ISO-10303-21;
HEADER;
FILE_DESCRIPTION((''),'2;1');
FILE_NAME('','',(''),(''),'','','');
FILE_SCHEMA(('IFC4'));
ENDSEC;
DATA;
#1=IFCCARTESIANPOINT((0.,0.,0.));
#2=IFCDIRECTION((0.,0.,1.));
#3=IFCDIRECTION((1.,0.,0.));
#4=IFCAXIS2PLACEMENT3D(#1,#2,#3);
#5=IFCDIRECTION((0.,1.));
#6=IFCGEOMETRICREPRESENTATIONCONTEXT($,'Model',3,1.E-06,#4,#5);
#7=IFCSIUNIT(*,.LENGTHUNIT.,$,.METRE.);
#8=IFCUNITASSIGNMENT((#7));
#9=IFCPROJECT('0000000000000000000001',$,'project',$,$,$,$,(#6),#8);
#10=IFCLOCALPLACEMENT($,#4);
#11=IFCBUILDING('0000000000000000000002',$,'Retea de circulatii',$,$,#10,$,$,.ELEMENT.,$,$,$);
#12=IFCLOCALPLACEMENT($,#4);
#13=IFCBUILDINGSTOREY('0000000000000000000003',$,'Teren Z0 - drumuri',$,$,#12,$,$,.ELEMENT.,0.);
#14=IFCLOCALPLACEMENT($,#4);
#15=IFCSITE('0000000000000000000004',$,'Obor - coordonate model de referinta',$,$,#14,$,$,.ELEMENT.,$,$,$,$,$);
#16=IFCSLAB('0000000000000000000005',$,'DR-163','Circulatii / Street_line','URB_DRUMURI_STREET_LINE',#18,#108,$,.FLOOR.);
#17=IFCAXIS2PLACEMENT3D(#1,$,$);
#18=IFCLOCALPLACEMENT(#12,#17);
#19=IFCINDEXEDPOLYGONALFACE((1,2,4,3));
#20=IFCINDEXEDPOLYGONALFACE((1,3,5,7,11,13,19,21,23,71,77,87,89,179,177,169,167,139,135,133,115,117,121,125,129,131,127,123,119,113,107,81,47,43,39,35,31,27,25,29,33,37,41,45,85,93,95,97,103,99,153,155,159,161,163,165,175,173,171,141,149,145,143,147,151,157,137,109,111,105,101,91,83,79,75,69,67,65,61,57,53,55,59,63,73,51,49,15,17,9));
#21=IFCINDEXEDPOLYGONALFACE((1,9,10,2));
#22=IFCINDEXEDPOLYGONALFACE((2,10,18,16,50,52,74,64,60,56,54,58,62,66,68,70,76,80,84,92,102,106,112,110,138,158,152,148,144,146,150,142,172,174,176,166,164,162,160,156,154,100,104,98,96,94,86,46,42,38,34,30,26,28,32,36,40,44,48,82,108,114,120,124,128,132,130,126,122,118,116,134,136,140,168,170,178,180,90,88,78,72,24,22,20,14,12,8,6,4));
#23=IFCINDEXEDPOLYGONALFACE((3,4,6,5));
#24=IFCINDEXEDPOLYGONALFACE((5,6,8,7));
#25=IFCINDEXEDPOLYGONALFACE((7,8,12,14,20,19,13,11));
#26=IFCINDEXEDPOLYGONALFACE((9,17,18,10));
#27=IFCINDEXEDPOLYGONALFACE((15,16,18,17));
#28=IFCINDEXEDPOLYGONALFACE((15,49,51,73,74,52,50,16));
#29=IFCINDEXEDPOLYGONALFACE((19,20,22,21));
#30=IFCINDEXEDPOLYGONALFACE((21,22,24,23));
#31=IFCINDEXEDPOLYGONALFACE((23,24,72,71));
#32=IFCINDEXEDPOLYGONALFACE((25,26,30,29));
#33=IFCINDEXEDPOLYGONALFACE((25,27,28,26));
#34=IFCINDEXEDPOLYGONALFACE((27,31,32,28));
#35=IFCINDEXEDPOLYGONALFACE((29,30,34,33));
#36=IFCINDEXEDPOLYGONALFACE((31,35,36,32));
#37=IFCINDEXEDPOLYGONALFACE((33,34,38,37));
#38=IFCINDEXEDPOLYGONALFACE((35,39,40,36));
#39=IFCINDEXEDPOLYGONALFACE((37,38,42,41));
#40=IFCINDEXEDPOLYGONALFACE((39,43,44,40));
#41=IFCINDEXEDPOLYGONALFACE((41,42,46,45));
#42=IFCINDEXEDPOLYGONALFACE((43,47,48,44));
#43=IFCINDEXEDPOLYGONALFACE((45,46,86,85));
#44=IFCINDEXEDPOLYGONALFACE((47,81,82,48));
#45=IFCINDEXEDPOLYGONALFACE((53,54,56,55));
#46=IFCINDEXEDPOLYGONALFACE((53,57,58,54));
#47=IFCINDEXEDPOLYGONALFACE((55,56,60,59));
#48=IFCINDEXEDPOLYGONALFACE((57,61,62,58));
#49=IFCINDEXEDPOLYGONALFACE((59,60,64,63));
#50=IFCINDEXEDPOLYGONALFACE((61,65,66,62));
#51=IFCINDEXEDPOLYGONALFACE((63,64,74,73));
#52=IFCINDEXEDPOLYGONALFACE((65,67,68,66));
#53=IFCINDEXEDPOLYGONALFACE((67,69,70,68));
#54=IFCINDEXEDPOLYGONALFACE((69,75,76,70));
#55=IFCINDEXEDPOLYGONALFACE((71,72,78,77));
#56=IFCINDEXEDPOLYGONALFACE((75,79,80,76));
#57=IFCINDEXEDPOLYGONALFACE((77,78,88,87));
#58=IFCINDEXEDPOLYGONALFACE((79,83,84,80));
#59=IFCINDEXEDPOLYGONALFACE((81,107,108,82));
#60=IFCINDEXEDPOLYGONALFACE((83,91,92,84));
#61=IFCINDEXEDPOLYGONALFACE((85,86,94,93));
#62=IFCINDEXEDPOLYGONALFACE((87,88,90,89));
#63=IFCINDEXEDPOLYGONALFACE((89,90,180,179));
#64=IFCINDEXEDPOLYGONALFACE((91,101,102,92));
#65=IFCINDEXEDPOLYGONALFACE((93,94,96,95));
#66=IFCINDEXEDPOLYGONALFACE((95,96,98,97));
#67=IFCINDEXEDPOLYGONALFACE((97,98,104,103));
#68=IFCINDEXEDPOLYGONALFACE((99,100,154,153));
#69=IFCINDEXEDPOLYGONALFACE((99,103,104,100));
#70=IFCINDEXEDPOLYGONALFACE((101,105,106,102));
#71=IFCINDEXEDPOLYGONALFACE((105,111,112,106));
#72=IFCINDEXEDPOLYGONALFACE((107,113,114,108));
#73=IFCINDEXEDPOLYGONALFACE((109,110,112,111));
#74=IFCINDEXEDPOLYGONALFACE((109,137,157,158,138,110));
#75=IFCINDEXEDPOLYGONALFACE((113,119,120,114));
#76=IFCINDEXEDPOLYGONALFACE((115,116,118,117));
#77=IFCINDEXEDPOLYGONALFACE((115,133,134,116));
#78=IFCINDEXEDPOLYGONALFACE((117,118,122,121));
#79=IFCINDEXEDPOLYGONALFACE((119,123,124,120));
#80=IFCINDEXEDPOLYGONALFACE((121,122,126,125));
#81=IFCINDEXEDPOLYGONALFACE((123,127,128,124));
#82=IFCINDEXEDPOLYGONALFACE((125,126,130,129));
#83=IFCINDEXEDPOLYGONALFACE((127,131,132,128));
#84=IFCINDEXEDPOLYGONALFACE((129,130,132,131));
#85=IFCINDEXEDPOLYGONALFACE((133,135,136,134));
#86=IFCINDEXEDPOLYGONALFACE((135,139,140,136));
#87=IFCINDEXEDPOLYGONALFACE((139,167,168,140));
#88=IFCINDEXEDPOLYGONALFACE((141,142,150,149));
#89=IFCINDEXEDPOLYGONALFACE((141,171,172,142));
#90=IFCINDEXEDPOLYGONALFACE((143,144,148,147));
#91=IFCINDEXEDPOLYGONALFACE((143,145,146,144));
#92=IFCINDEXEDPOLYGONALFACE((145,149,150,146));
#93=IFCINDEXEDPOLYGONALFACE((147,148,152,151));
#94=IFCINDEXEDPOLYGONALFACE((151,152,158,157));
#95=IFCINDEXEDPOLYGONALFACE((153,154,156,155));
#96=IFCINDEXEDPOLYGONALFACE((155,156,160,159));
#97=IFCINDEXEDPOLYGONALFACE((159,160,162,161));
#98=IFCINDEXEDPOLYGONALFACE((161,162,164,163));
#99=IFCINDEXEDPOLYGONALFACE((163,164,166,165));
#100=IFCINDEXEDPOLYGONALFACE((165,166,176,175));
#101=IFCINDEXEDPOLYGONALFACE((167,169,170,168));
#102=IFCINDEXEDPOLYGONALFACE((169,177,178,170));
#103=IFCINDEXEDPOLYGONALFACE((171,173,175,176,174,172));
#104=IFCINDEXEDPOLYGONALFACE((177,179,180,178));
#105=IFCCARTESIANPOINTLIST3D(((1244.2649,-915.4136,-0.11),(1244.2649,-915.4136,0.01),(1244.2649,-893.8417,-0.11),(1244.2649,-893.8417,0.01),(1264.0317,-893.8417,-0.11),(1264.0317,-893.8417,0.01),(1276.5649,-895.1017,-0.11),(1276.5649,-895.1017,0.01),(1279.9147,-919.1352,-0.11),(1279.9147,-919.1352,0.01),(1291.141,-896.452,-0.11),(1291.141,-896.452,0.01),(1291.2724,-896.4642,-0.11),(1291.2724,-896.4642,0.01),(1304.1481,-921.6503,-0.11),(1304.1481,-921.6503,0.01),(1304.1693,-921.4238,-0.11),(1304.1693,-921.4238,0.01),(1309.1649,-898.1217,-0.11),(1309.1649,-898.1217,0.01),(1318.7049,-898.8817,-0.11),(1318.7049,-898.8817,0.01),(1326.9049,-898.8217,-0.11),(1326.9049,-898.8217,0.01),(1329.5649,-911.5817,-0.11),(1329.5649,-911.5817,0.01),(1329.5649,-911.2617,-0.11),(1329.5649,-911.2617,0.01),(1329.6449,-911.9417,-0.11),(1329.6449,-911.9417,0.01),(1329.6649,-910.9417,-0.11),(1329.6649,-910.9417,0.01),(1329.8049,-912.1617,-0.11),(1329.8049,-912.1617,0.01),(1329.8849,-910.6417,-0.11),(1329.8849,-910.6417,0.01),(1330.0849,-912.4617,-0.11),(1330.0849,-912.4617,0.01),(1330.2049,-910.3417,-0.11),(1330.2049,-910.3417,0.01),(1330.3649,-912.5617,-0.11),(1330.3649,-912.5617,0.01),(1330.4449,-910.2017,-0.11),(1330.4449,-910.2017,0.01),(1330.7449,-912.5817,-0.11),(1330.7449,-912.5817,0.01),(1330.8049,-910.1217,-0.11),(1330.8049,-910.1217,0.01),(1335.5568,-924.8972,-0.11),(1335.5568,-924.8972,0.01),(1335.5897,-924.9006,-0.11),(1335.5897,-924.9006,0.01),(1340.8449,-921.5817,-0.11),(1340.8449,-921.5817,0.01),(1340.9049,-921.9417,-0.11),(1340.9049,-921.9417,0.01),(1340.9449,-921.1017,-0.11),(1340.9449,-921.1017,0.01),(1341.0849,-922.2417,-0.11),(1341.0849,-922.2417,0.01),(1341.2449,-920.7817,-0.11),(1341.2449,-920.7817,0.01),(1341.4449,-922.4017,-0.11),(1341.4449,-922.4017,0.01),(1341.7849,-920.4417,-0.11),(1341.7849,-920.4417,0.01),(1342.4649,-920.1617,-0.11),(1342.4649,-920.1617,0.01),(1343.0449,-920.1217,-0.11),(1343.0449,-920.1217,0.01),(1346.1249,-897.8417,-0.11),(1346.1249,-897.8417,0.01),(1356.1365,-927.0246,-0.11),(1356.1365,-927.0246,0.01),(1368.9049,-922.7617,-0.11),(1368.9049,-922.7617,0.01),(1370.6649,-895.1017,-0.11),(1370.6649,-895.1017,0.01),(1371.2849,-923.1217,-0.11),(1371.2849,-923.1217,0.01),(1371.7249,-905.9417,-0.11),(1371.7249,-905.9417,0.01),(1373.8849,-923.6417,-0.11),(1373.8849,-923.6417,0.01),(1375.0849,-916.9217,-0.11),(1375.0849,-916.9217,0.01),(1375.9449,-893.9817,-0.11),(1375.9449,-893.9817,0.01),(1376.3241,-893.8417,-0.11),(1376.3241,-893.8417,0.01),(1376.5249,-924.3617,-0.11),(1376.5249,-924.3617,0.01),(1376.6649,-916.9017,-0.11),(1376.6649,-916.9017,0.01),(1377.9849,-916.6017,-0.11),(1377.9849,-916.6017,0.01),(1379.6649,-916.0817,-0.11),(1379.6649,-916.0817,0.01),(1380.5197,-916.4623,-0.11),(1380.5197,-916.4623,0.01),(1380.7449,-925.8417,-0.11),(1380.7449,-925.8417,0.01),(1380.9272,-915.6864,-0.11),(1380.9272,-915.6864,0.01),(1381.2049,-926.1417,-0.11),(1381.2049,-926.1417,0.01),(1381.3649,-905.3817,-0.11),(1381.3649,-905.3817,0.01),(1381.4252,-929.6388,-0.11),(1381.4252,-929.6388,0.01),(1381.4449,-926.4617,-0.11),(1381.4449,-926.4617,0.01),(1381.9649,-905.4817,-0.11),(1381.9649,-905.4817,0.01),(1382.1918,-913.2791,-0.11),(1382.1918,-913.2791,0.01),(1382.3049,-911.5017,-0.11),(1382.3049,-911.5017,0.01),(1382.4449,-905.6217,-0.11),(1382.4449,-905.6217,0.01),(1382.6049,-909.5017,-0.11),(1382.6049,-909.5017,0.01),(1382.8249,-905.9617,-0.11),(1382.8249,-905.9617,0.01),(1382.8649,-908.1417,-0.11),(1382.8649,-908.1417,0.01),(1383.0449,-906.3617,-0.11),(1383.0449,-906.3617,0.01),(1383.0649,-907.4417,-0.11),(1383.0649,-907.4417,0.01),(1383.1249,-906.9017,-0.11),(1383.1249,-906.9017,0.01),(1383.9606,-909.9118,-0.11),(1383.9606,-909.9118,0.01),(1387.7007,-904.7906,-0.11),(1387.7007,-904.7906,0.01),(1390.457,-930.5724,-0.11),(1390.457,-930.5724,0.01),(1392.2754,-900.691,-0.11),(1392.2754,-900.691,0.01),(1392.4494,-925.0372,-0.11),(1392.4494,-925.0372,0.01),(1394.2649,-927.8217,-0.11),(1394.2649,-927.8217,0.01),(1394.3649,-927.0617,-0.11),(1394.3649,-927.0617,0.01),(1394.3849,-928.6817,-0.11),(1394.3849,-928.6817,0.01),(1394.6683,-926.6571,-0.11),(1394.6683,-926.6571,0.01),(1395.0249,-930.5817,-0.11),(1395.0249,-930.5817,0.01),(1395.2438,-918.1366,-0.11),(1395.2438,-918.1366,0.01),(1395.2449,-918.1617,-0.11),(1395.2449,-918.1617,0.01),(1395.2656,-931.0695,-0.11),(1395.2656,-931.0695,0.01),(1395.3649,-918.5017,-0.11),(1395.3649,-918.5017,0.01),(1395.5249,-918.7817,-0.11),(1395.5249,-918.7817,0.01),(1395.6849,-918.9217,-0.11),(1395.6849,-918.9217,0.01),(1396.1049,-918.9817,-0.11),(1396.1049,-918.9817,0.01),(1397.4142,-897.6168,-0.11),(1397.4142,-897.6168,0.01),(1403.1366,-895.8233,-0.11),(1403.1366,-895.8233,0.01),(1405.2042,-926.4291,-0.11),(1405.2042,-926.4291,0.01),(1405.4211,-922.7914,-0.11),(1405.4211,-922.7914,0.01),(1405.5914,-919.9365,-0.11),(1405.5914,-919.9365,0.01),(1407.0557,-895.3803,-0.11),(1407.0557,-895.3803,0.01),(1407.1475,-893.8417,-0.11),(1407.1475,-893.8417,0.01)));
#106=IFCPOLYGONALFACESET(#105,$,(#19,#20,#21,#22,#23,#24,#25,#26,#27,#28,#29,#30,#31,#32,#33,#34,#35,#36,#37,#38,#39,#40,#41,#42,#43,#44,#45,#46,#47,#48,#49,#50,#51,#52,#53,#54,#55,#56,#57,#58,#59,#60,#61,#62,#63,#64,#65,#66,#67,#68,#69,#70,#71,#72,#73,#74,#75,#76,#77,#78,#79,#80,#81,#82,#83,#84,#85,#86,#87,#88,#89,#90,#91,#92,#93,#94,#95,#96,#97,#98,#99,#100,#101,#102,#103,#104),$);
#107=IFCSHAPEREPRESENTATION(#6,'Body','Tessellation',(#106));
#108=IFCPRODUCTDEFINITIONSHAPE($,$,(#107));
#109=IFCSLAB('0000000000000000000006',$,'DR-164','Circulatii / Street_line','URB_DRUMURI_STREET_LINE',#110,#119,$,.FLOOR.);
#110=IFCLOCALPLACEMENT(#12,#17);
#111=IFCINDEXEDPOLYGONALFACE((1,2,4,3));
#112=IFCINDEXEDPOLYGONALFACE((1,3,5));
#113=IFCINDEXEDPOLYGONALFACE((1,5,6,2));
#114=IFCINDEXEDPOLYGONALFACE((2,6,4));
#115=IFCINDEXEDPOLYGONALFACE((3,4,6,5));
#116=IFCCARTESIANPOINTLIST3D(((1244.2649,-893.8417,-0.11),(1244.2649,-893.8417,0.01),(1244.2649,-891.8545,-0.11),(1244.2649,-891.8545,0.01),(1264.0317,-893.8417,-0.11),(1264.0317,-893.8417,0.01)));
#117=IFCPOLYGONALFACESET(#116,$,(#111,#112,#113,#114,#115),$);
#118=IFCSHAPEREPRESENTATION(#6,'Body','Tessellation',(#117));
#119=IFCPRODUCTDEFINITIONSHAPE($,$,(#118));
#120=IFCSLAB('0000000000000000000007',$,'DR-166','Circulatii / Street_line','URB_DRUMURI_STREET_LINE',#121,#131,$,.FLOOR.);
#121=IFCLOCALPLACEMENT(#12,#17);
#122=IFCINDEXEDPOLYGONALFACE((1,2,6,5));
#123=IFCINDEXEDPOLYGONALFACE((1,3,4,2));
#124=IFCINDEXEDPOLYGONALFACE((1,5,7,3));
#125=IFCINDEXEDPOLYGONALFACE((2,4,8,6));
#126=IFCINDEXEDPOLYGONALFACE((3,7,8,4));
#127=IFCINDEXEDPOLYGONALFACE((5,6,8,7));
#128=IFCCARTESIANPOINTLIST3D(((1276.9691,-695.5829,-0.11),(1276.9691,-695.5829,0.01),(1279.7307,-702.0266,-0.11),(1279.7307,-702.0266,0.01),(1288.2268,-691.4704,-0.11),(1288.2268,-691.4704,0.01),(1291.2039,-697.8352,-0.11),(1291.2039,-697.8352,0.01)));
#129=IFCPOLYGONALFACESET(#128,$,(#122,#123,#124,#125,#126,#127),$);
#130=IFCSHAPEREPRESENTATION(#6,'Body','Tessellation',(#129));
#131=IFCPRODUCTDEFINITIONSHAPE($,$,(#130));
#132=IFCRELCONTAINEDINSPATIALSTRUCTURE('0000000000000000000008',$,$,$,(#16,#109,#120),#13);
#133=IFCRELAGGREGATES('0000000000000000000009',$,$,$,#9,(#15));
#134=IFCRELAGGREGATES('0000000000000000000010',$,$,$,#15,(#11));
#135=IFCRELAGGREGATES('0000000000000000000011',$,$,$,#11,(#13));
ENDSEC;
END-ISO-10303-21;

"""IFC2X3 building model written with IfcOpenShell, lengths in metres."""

from ifc_helpers import new_model, si_unit, direction, frame, origin_with_axes, place, context, project, spatial, polyline, outline, extrude, element, save


model = new_model("IFC2X3")

# Units and contexts
model_context = context("Model", 3, precision=1e-06, world=origin_with_axes(), true_north=direction((0.0, 1.0)))
ifc_project = project(units=[si_unit("LENGTHUNIT", "METRE")], contexts=[model_context])

# Site, building, storey
site_placement = place(None, origin_with_axes())
site = spatial("IfcSite", under=ifc_project, at=site_placement, Name="Obor - coordonate model de referinta", CompositionType="ELEMENT")
building_placement = place(None, origin_with_axes())
building = spatial("IfcBuilding", under=site, at=building_placement, Name="Retea de circulatii", CompositionType="ELEMENT")
storey_placement = place(None, origin_with_axes())
storey = spatial("IfcBuildingStorey", under=building, at=storey_placement, Name="Teren Z0 - drumuri", CompositionType="ELEMENT", Elevation=0.0)

# Slabs
slab_1_placement = place(None, origin_with_axes())
element("IfcSlab", 1, at=slab_1_placement, inside=storey, Name="DR-163", Description="Circulatii / Street_line", ObjectType="URB_DRUMURI_STREET_LINE", PredefinedType="FLOOR", context=model_context, shape_type="SweptSolid", body=[
    extrude(outline(polyline([(1407.0557, -895.3803), (1407.1475, -893.8417), (1376.3241, -893.8417), (1375.9449, -893.9817), (1370.6649, -895.1017), (1346.1249, -897.8417), (1326.9049, -898.8217), (1318.7049, -898.8817), (1309.1649, -898.1217), (1291.2724, -896.4642), (1291.141, -896.452), (1276.5649, -895.1017), (1264.0317, -893.8417), (1244.2649, -893.8417), (1244.2649, -915.4136), (1289.7366, -920.1605), (1279.9147, -919.1352), (1304.1693, -921.4238), (1304.1481, -921.6503), (1335.5568, -924.8972), (1335.5897, -924.9006), (1356.1365, -927.0246), (1341.4449, -922.4017), (1341.0849, -922.2417), (1340.9049, -921.9417), (1340.8449, -921.5817), (1340.9449, -921.1017), (1341.2449, -920.7817), (1341.7849, -920.4417), (1342.4649, -920.1617), (1343.0449, -920.1217), (1368.9049, -922.7617), (1371.2849, -923.1217), (1373.8849, -923.6417), (1376.5249, -924.3617), (1380.7449, -925.8417), (1381.2049, -926.1417), (1381.4449, -926.4617), (1381.4252, -929.6388), (1390.457, -930.5724), (1395.2656, -931.0695), (1395.0249, -930.5817), (1394.3849, -928.6817), (1394.2649, -927.8217), (1394.3649, -927.0617), (1394.6683, -926.6571), (1392.4494, -925.0372), (1405.2042, -926.4291), (1405.1671, -927.0517), (1405.4211, -922.7914), (1405.5914, -919.9365), (1396.1049, -918.9817), (1395.6849, -918.9217), (1395.5249, -918.7817), (1395.3649, -918.5017), (1395.2449, -918.1617), (1395.2438, -918.1366), (1380.5197, -916.4623), (1380.9272, -915.6864), (1379.6649, -916.0817), (1377.9849, -916.6017), (1376.6649, -916.9017), (1375.0849, -916.9217), (1330.7449, -912.5817), (1330.3649, -912.5617), (1330.0849, -912.4617), (1329.8049, -912.1617), (1329.6449, -911.9417), (1329.5649, -911.5817), (1329.5649, -911.2617), (1329.6649, -910.9417), (1329.8849, -910.6417), (1330.2049, -910.3417), (1330.4449, -910.2017), (1330.8049, -910.1217), (1371.7249, -905.9417), (1381.3649, -905.3817), (1381.9649, -905.4817), (1382.4449, -905.6217), (1382.8249, -905.9617), (1383.0449, -906.3617), (1383.1249, -906.9017), (1383.0649, -907.4417), (1382.8649, -908.1417), (1382.6049, -909.5017), (1382.3049, -911.5017), (1382.1918, -913.2791), (1383.9606, -909.9118), (1387.7007, -904.7906), (1392.2754, -900.691), (1397.4142, -897.6168), (1403.1366, -895.8233), (1407.0557, -895.3803)])), frame((0.0, 0.0, -0.11), z_axis=(0.0, 0.0, 1.0), x_axis=(1.0, 0.0, 0.0)), (0.0, 0.0, 1.0), 0.12),
])
slab_2_placement = place(None, origin_with_axes())
element("IfcSlab", 2, at=slab_2_placement, inside=storey, Name="DR-164", Description="Circulatii / Street_line", ObjectType="URB_DRUMURI_STREET_LINE", PredefinedType="FLOOR", context=model_context, shape_type="SweptSolid", body=[
    extrude(outline(polyline([(1244.2649, -891.8545), (1244.2649, -893.8417), (1264.0317, -893.8417), (1244.2649, -891.8545)])), frame((0.0, 0.0, -0.11), z_axis=(0.0, 0.0, 1.0), x_axis=(1.0, 0.0, 0.0)), (0.0, 0.0, 1.0), 0.12),
])
slab_3_placement = place(None, origin_with_axes())
element("IfcSlab", 3, at=slab_3_placement, inside=storey, Name="DR-166", Description="Circulatii / Street_line", ObjectType="URB_DRUMURI_STREET_LINE", PredefinedType="FLOOR", context=model_context, shape_type="SweptSolid", body=[
    extrude(outline(polyline([(1279.7307, -702.0266), (1291.2039, -697.8352), (1288.2268, -691.4704), (1276.9691, -695.5829), (1279.7307, -702.0266)])), frame((0.0, 0.0, -0.11), z_axis=(0.0, 0.0, 1.0), x_axis=(1.0, 0.0, 0.0)), (0.0, 0.0, 1.0), 0.12),
])

save(model, "model.ifc")
